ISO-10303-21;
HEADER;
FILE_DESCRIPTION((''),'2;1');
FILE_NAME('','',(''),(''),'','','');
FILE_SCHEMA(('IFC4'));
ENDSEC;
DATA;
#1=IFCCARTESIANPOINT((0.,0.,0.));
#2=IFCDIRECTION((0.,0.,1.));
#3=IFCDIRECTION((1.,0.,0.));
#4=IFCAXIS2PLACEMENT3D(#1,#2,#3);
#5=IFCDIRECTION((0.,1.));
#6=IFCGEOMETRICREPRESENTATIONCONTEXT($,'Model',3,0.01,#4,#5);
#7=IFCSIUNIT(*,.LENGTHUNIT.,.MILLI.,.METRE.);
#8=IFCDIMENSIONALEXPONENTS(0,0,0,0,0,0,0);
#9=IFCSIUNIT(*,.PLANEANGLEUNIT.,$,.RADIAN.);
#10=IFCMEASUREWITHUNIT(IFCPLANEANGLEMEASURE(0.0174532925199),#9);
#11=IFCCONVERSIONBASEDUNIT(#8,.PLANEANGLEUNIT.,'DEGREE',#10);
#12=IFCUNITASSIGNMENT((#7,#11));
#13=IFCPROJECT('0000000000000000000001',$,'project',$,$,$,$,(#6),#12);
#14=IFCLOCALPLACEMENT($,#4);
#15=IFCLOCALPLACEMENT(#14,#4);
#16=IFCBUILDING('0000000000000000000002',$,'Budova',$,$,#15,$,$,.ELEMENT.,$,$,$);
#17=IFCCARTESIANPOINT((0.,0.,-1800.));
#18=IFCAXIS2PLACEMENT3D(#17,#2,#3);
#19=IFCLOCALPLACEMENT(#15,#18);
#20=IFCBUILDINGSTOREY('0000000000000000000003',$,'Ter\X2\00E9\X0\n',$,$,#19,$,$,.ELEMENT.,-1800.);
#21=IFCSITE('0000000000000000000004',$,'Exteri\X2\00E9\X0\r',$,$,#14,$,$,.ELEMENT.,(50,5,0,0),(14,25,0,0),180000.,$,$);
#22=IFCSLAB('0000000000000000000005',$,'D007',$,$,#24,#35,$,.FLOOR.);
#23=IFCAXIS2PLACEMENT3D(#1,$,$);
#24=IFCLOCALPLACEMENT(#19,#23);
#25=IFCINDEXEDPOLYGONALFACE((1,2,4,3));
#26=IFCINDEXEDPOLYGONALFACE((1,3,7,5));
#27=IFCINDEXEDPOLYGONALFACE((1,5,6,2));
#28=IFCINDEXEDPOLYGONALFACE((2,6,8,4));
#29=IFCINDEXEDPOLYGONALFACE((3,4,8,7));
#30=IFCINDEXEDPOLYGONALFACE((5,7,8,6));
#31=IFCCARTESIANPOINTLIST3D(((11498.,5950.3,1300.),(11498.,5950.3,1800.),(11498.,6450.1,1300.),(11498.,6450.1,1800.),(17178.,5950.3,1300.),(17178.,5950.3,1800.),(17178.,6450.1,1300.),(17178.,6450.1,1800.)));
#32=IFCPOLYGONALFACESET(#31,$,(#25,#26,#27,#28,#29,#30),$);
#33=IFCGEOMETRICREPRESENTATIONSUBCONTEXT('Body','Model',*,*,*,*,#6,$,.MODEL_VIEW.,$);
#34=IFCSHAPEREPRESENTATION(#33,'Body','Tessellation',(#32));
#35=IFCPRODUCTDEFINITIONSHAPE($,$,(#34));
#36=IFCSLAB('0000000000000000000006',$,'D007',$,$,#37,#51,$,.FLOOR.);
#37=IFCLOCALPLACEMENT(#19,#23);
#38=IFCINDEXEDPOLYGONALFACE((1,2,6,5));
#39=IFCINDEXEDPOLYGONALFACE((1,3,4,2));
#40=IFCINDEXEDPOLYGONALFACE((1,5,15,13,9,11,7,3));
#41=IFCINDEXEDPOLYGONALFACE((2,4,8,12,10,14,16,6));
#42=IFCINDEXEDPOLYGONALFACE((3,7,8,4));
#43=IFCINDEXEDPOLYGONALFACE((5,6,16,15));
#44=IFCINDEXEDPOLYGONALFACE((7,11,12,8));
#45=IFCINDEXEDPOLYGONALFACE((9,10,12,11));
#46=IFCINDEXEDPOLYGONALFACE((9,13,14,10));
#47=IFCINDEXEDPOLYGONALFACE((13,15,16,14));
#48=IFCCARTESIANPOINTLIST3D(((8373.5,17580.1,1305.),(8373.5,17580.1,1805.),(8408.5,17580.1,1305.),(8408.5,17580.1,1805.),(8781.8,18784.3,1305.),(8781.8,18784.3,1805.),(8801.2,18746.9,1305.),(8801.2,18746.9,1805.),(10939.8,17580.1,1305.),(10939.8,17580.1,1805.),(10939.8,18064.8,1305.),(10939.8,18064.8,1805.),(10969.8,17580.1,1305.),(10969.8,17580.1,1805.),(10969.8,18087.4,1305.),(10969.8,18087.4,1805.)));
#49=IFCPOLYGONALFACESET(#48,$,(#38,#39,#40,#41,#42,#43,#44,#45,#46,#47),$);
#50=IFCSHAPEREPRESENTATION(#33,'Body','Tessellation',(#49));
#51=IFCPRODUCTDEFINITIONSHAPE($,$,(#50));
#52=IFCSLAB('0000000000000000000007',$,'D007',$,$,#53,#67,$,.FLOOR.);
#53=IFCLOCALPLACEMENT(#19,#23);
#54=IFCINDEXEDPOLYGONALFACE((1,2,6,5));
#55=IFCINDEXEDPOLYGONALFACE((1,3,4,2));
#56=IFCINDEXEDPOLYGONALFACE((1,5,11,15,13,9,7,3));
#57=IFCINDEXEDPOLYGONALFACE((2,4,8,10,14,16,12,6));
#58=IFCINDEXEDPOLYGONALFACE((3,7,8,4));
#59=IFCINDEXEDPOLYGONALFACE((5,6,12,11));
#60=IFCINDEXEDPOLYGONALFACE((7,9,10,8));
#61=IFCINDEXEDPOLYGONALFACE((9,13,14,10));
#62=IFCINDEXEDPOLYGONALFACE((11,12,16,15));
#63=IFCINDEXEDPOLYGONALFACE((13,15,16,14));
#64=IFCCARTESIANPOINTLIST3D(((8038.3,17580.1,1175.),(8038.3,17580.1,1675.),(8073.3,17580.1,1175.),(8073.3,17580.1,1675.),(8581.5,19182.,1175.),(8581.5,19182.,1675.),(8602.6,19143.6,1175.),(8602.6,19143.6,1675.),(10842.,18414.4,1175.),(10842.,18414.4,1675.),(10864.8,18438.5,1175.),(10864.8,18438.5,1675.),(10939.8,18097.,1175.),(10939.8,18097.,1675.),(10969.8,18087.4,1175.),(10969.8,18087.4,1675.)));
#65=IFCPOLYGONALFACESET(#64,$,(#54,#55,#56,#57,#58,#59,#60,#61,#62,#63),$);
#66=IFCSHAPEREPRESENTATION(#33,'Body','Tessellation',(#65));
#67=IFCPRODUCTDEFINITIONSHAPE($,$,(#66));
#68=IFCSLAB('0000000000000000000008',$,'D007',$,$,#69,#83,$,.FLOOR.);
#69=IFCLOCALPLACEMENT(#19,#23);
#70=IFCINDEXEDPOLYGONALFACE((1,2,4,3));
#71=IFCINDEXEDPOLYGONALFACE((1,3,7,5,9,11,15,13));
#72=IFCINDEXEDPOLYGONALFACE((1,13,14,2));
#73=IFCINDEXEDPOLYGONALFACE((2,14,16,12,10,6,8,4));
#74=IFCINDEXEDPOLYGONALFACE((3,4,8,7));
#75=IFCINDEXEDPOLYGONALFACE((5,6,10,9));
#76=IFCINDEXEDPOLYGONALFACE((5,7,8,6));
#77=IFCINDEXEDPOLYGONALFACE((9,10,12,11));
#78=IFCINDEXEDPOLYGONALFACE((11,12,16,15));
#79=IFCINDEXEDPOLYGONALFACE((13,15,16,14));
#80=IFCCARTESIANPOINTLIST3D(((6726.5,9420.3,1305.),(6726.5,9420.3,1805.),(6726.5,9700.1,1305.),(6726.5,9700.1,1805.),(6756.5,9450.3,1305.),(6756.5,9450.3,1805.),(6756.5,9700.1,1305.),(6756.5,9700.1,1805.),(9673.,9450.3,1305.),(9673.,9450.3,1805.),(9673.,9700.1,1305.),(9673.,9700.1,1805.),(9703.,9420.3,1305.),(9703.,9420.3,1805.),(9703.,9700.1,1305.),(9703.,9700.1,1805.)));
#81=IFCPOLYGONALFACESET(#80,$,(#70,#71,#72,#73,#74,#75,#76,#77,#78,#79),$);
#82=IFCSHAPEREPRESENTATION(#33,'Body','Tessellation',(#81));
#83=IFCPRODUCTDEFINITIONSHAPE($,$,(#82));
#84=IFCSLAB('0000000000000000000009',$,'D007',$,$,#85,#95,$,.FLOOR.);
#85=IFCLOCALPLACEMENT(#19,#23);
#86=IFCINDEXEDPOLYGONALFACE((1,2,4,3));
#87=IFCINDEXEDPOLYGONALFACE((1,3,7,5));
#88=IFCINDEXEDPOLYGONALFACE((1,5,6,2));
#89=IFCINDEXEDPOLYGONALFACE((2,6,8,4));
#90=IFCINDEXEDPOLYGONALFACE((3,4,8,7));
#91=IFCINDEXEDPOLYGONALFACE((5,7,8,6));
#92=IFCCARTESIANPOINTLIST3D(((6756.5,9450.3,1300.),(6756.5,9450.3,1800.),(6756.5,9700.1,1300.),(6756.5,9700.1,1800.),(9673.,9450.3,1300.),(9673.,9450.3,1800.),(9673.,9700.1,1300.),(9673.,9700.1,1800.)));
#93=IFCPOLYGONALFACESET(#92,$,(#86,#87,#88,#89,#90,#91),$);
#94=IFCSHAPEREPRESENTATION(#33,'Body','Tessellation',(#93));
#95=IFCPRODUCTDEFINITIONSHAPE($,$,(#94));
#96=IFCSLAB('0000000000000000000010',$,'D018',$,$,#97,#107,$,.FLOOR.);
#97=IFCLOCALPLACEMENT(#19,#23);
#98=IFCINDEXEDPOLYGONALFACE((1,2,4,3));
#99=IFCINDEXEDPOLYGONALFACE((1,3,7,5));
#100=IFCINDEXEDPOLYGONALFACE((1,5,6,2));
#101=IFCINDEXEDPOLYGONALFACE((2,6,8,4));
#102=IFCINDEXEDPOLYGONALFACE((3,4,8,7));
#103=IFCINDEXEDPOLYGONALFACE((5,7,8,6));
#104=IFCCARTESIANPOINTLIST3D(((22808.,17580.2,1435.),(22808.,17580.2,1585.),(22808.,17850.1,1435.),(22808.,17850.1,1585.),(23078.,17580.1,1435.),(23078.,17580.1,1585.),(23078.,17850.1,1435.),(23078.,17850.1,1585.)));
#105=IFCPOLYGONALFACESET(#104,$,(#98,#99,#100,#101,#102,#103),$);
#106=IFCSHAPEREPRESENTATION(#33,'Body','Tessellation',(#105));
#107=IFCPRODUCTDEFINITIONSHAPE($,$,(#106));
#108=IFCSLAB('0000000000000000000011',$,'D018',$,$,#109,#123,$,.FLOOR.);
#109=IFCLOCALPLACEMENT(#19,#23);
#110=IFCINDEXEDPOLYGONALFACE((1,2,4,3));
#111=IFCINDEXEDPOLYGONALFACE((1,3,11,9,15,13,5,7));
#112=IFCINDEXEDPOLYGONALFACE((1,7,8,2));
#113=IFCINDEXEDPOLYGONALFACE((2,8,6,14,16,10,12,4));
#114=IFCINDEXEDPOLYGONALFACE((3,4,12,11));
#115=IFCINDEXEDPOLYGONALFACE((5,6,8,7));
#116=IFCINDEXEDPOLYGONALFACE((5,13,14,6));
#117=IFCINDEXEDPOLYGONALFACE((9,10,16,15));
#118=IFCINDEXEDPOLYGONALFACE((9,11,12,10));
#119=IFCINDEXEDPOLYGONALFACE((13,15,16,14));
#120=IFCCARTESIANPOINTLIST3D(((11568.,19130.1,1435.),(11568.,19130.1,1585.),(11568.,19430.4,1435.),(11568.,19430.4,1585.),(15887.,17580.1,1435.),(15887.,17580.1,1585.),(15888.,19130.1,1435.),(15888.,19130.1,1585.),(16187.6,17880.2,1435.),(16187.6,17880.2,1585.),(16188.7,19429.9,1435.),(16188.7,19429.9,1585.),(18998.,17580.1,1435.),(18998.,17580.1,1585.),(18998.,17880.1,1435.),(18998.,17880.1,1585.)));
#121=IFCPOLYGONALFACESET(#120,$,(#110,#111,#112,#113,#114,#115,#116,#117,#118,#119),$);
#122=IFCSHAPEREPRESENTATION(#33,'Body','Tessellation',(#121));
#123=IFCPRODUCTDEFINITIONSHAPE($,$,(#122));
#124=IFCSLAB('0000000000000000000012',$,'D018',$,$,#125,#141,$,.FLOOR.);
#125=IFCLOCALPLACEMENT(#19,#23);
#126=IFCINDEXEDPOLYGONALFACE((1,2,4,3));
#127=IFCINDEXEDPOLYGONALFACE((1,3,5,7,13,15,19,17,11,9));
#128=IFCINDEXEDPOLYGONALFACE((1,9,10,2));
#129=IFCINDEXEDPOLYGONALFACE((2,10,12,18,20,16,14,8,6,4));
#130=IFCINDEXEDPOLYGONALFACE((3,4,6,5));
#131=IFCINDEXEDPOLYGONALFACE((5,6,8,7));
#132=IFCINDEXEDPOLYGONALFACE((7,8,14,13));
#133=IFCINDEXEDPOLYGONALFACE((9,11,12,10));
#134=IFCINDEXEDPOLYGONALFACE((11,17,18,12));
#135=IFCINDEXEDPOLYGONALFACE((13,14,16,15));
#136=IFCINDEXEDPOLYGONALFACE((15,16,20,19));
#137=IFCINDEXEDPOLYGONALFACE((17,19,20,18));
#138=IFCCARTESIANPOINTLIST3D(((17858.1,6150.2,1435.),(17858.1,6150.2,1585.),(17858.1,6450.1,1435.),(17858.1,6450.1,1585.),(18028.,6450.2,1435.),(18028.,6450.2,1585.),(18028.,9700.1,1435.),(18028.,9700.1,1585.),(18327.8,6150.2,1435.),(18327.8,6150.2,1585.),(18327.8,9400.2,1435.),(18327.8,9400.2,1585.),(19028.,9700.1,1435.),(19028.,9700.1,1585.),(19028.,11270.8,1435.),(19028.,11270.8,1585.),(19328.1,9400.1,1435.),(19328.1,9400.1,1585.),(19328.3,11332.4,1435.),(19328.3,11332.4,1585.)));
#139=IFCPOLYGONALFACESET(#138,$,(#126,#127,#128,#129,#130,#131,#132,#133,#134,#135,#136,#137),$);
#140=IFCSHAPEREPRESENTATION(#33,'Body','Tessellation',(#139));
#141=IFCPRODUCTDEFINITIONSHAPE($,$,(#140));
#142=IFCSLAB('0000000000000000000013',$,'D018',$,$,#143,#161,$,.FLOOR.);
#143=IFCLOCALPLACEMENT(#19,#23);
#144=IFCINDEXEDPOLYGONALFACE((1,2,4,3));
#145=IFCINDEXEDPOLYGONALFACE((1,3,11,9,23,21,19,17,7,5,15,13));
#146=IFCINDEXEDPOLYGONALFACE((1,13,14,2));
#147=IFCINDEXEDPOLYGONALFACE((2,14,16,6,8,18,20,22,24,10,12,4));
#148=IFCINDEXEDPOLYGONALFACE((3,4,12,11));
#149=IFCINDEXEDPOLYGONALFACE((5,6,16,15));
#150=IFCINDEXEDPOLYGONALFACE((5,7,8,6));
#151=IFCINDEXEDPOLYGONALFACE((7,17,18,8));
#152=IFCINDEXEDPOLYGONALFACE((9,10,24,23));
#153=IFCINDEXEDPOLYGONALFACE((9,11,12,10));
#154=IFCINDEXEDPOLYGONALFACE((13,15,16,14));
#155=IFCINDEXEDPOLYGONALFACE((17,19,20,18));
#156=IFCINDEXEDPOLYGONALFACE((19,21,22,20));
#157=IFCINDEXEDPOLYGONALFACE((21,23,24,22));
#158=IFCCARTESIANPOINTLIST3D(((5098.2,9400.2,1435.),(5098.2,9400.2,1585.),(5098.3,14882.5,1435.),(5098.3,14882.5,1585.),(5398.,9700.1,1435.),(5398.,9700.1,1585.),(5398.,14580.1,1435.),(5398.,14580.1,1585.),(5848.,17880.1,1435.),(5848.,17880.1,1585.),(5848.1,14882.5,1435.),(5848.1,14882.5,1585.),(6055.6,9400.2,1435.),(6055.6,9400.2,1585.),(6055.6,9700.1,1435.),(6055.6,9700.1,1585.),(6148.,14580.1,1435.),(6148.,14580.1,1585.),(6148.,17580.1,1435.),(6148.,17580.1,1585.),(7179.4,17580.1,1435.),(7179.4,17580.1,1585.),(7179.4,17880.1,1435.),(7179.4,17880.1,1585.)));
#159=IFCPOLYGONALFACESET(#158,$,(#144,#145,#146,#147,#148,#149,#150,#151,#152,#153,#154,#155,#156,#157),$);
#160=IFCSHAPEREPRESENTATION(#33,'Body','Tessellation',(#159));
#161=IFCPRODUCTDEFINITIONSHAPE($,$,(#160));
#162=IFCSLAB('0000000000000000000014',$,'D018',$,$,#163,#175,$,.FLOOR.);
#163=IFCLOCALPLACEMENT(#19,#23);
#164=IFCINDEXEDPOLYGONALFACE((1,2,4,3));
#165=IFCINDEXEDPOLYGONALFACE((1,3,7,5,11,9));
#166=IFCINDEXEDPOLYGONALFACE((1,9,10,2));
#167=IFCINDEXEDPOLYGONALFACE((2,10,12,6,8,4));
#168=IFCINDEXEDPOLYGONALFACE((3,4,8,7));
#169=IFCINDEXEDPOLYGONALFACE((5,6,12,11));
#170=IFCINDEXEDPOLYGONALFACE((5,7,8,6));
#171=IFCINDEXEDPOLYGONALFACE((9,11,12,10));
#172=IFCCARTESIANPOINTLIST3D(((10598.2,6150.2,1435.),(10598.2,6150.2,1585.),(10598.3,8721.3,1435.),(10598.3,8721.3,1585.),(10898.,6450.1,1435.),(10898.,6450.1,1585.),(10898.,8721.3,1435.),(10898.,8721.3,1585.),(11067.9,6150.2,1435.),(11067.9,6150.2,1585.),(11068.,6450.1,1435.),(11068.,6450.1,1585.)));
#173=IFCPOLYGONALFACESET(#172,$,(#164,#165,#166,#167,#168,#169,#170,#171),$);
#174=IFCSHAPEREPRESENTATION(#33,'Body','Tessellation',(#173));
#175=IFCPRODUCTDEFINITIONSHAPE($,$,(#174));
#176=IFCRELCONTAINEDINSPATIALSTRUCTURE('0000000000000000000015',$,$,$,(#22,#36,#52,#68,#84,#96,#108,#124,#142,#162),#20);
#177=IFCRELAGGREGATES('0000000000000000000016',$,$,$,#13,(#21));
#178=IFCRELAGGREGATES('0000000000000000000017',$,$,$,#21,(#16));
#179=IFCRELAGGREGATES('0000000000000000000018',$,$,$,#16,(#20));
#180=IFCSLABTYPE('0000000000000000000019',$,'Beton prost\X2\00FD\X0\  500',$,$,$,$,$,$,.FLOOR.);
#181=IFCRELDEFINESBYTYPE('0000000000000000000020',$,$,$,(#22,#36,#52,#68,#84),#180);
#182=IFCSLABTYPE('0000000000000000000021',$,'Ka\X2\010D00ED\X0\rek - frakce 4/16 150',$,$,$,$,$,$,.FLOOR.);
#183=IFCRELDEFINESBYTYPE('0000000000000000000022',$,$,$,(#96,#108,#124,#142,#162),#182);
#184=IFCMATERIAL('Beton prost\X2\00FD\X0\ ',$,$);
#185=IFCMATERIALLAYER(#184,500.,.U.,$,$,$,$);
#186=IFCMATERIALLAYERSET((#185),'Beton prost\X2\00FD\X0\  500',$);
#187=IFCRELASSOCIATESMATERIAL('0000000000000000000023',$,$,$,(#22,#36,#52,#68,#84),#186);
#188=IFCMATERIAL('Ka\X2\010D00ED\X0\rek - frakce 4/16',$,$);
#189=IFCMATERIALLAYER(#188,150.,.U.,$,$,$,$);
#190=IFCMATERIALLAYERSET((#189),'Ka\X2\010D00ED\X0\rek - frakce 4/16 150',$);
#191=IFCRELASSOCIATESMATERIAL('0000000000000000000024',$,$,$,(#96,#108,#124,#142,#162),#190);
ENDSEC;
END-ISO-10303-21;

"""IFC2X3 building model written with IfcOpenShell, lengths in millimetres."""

from ifc_helpers import new_model, entity, si_unit, converted_unit, direction, frame, origin_with_axes, place, context, subcontext, project, spatial, polyline, outline, extrude, material, layer, layer_set, layer_usage, type_object, element, save


model = new_model("IFC2X3")

# Units and contexts
model_context = context("Model", 3, precision=0.01, world=origin_with_axes(), true_north=direction((0.0, 1.0)))
body_context = subcontext(model_context, "Body", "Model", "MODEL_VIEW")
ifc_project = project(units=[si_unit("LENGTHUNIT", "METRE", prefix="MILLI"), converted_unit("PLANEANGLEUNIT", "DEGREE", entity("IfcPlaneAngleMeasure", 0.0174532925199), si_unit("PLANEANGLEUNIT", "RADIAN"), dimensions=[0, 0, 0, 0, 0, 0, 0])], contexts=[model_context])

# Site, building, storey
site_placement = place(None, origin_with_axes())
site = spatial("IfcSite", under=ifc_project, at=site_placement, Name="Exteriér", CompositionType="ELEMENT", RefLatitude=(50, 5, 0, 0), RefLongitude=(14, 25, 0, 0), RefElevation=180000.0)
building_placement = place(site_placement, origin_with_axes())
building = spatial("IfcBuilding", under=site, at=building_placement, Name="Budova", CompositionType="ELEMENT")
storey_placement = place(building_placement, frame((0.0, 0.0, -1800.0), z_axis=(0.0, 0.0, 1.0), x_axis=(1.0, 0.0, 0.0)))
storey = spatial("IfcBuildingStorey", under=building, at=storey_placement, Name="Terén", CompositionType="ELEMENT", Elevation=-1800.0)

# Slabs
ifc_material_1 = material(Name="Beton prostý ")
ifc_layer_1 = layer(ifc_material_1, 500.0, ventilated="UNKNOWN")
ifc_layer_set_1 = layer_set([ifc_layer_1], Name="Beton prostý  500")
slab_type_1 = type_object("IfcSlabType", Name="Beton prostý  500", PredefinedType="FLOOR")
ifc_layer_usage_1 = layer_usage(ifc_layer_set_1, "AXIS3", "NEGATIVE", 500.0)
slab_1_placement = place(storey_placement, frame((11498.0, 5950.3, 1800.0), z_axis=(0.0, 0.0, 1.0), x_axis=(1.0, 0.0, 0.0)))
element("IfcSlab", 1, at=slab_1_placement, inside=storey, type_object=slab_type_1, material=ifc_layer_usage_1, Name="D007", PredefinedType="FLOOR", context=body_context, shape_type="SweptSolid", body=[
    extrude(outline(polyline([(0.0, 0.0), (5680.0, 0.0), (5680.0, 499.8), (0.0, 499.8), (0.0, 0.0)])), frame((0.0, 0.0, -500.0), z_axis=(0.0, 0.0, 1.0), x_axis=(1.0, 0.0, 0.0)), (0.0, 0.0, 1.0), 500.0),
])
ifc_layer_usage_2 = layer_usage(ifc_layer_set_1, "AXIS3", "NEGATIVE", 500.0)
slab_2_placement = place(storey_placement, frame((10969.8, 17580.1, 1805.0), z_axis=(0.0, 0.0, 1.0), x_axis=(1.0, 0.0, 0.0)))
element("IfcSlab", 2, at=slab_2_placement, inside=storey, type_object=slab_type_1, material=ifc_layer_usage_2, Name="D007", PredefinedType="FLOOR", context=body_context, shape_type="SweptSolid", body=[
    extrude(outline(polyline([(0.0, 0.0), (0.0, 507.3), (-2188.0, 1204.1), (-2596.3, 0.0), (-2561.3, 0.0), (-2168.6, 1166.8), (-30.0, 484.6), (-30.0, 0.0), (0.0, 0.0)])), frame((0.0, 0.0, -500.0), z_axis=(0.0, 0.0, 1.0), x_axis=(1.0, 0.0, 0.0)), (0.0, 0.0, 1.0), 500.0),
])
ifc_layer_usage_3 = layer_usage(ifc_layer_set_1, "AXIS3", "NEGATIVE", 500.0)
slab_3_placement = place(storey_placement, frame((10969.8, 18087.4, 1675.0), z_axis=(0.0, 0.0, 1.0), x_axis=(1.0, 0.0, 0.0)))
element("IfcSlab", 3, at=slab_3_placement, inside=storey, type_object=slab_type_1, material=ifc_layer_usage_3, Name="D007", PredefinedType="FLOOR", context=body_context, shape_type="SweptSolid", body=[
    extrude(outline(polyline([(0.0, 0.0), (-105.1, 351.1), (-2388.4, 1094.6), (-2931.5, -507.3), (-2896.5, -507.3), (-2367.2, 1056.2), (-127.8, 327.0), (-30.0, 9.6), (0.0, 0.0)])), frame((0.0, 0.0, -500.0), z_axis=(0.0, 0.0, 1.0), x_axis=(1.0, 0.0, 0.0)), (0.0, 0.0, 1.0), 500.0),
])
ifc_layer_usage_4 = layer_usage(ifc_layer_set_1, "AXIS3", "NEGATIVE", 500.0)
slab_4_placement = place(storey_placement, frame((6726.5, 9420.3, 1805.0), z_axis=(0.0, 0.0, 1.0), x_axis=(1.0, 0.0, 0.0)))
element("IfcSlab", 4, at=slab_4_placement, inside=storey, type_object=slab_type_1, material=ifc_layer_usage_4, Name="D007", PredefinedType="FLOOR", context=body_context, shape_type="SweptSolid", body=[
    extrude(outline(polyline([(0.0, 0.0), (2976.4, 0.0), (2976.4, 279.8), (2946.4, 279.8), (2946.4, 30.0), (30.0, 30.0), (30.0, 279.8), (0.0, 279.8), (0.0, 0.0)])), frame((0.0, 0.0, -500.0), z_axis=(0.0, 0.0, 1.0), x_axis=(1.0, 0.0, 0.0)), (0.0, 0.0, 1.0), 500.0),
])
ifc_layer_usage_5 = layer_usage(ifc_layer_set_1, "AXIS3", "NEGATIVE", 500.0)
slab_5_placement = place(storey_placement, frame((6756.5, 9700.1, 1800.0), z_axis=(0.0, 0.0, 1.0), x_axis=(1.0, 0.0, 0.0)))
element("IfcSlab", 5, at=slab_5_placement, inside=storey, type_object=slab_type_1, material=ifc_layer_usage_5, Name="D007", PredefinedType="FLOOR", context=body_context, shape_type="SweptSolid", body=[
    extrude(outline(polyline([(0.0, 0.0), (0.0, -249.8), (2916.4, -249.8), (2916.4, 0.0), (0.0, 0.0)])), frame((0.0, 0.0, -500.0), z_axis=(0.0, 0.0, 1.0), x_axis=(1.0, 0.0, 0.0)), (0.0, 0.0, 1.0), 500.0),
])
ifc_material_2 = material(Name="Kačírek - frakce 4/16")
ifc_layer_2 = layer(ifc_material_2, 150.0, ventilated="UNKNOWN")
ifc_layer_set_2 = layer_set([ifc_layer_2], Name="Kačírek - frakce 4/16 150")
ifc_layer_usage_6 = layer_usage(ifc_layer_set_2, "AXIS3", "NEGATIVE", 150.0)
slab_type_2 = type_object("IfcSlabType", Name="Kačírek - frakce 4/16 150", PredefinedType="FLOOR")
slab_6_placement = place(storey_placement, frame((22808.0, 17580.2, 1585.0), z_axis=(0.0, 0.0, 1.0), x_axis=(1.0, 0.0, 0.0)))
element("IfcSlab", 6, at=slab_6_placement, inside=storey, type_object=slab_type_2, material=ifc_layer_usage_6, Name="D018", PredefinedType="FLOOR", context=body_context, shape_type="SweptSolid", body=[
    extrude(outline(polyline([(0.0, 0.0), (270.0, -0.1), (270.0, 269.9), (0.0, 269.9), (0.0, 0.0)])), frame((0.0, 0.0, -150.0), z_axis=(0.0, 0.0, 1.0), x_axis=(1.0, 0.0, 0.0)), (0.0, 0.0, 1.0), 150.0),
])
ifc_layer_usage_7 = layer_usage(ifc_layer_set_2, "AXIS3", "NEGATIVE", 150.0)
slab_7_placement = place(storey_placement, frame((11568.0, 19430.4, 1585.0), z_axis=(0.0, 0.0, 1.0), x_axis=(1.0, 0.0, 0.0)))
element("IfcSlab", 7, at=slab_7_placement, inside=storey, type_object=slab_type_2, material=ifc_layer_usage_7, Name="D018", PredefinedType="FLOOR", context=body_context, shape_type="SweptSolid", body=[
    extrude(outline(polyline([(0.0, 0.0), (0.0, -300.3), (4320.0, -300.3), (4319.0, -1850.3), (7430.0, -1850.3), (7430.0, -1550.3), (4619.6, -1550.2), (4620.7, -0.5), (0.0, 0.0)])), frame((0.0, 0.0, -150.0), z_axis=(0.0, 0.0, 1.0), x_axis=(1.0, 0.0, 0.0)), (0.0, 0.0, 1.0), 150.0),
])
ifc_layer_usage_8 = layer_usage(ifc_layer_set_2, "AXIS3", "NEGATIVE", 150.0)
slab_8_placement = place(storey_placement, frame((18028.0, 6450.2, 1585.0), z_axis=(0.0, 0.0, 1.0), x_axis=(1.0, 0.0, 0.0)))
element("IfcSlab", 8, at=slab_8_placement, inside=storey, type_object=slab_type_2, material=ifc_layer_usage_8, Name="D018", PredefinedType="FLOOR", context=body_context, shape_type="SweptSolid", body=[
    extrude(outline(polyline([(0.0, 0.0), (-169.9, 0.0), (-169.9, -300.0), (299.8, -299.9), (299.8, 2950.1), (1300.1, 2950.0), (1300.3, 4882.2), (1000.0, 4820.6), (1000.0, 3250.0), (0.0, 3250.0), (0.0, 0.0)])), frame((0.0, 0.0, -150.0), z_axis=(0.0, 0.0, 1.0), x_axis=(1.0, 0.0, 0.0)), (0.0, 0.0, 1.0), 150.0),
])
ifc_layer_usage_9 = layer_usage(ifc_layer_set_2, "AXIS3", "NEGATIVE", 150.0)
slab_9_placement = place(storey_placement, frame((5098.2, 9400.2, 1585.0), z_axis=(0.0, 0.0, 1.0), x_axis=(1.0, 0.0, 0.0)))
element("IfcSlab", 9, at=slab_9_placement, inside=storey, type_object=slab_type_2, material=ifc_layer_usage_9, Name="D018", PredefinedType="FLOOR", context=body_context, shape_type="SweptSolid", body=[
    extrude(outline(polyline([(0.0, 0.0), (957.4, 0.0), (957.4, 299.9), (299.8, 299.9), (299.8, 5179.9), (1049.8, 5179.9), (1049.8, 8179.9), (2081.1, 8179.9), (2081.1, 8479.9), (749.8, 8479.9), (749.8, 5482.3), (0.0, 5482.3), (0.0, 0.0)])), frame((0.0, 0.0, -150.0), z_axis=(0.0, 0.0, 1.0), x_axis=(1.0, 0.0, 0.0)), (0.0, 0.0, 1.0), 150.0),
])
ifc_layer_usage_10 = layer_usage(ifc_layer_set_2, "AXIS3", "NEGATIVE", 150.0)
slab_10_placement = place(storey_placement, frame((10598.2, 6150.2, 1585.0), z_axis=(0.0, 0.0, 1.0), x_axis=(1.0, 0.0, 0.0)))
element("IfcSlab", 10, at=slab_10_placement, inside=storey, type_object=slab_type_2, material=ifc_layer_usage_10, Name="D018", PredefinedType="FLOOR", context=body_context, shape_type="SweptSolid", body=[
    extrude(outline(polyline([(0.0, 0.0), (469.7, 0.0), (469.7, 299.9), (299.8, 299.9), (299.8, 2571.1), (0.0, 2571.1), (0.0, 0.0)])), frame((0.0, 0.0, -150.0), z_axis=(0.0, 0.0, 1.0), x_axis=(1.0, 0.0, 0.0)), (0.0, 0.0, 1.0), 150.0),
])

save(model, "model.ifc")
